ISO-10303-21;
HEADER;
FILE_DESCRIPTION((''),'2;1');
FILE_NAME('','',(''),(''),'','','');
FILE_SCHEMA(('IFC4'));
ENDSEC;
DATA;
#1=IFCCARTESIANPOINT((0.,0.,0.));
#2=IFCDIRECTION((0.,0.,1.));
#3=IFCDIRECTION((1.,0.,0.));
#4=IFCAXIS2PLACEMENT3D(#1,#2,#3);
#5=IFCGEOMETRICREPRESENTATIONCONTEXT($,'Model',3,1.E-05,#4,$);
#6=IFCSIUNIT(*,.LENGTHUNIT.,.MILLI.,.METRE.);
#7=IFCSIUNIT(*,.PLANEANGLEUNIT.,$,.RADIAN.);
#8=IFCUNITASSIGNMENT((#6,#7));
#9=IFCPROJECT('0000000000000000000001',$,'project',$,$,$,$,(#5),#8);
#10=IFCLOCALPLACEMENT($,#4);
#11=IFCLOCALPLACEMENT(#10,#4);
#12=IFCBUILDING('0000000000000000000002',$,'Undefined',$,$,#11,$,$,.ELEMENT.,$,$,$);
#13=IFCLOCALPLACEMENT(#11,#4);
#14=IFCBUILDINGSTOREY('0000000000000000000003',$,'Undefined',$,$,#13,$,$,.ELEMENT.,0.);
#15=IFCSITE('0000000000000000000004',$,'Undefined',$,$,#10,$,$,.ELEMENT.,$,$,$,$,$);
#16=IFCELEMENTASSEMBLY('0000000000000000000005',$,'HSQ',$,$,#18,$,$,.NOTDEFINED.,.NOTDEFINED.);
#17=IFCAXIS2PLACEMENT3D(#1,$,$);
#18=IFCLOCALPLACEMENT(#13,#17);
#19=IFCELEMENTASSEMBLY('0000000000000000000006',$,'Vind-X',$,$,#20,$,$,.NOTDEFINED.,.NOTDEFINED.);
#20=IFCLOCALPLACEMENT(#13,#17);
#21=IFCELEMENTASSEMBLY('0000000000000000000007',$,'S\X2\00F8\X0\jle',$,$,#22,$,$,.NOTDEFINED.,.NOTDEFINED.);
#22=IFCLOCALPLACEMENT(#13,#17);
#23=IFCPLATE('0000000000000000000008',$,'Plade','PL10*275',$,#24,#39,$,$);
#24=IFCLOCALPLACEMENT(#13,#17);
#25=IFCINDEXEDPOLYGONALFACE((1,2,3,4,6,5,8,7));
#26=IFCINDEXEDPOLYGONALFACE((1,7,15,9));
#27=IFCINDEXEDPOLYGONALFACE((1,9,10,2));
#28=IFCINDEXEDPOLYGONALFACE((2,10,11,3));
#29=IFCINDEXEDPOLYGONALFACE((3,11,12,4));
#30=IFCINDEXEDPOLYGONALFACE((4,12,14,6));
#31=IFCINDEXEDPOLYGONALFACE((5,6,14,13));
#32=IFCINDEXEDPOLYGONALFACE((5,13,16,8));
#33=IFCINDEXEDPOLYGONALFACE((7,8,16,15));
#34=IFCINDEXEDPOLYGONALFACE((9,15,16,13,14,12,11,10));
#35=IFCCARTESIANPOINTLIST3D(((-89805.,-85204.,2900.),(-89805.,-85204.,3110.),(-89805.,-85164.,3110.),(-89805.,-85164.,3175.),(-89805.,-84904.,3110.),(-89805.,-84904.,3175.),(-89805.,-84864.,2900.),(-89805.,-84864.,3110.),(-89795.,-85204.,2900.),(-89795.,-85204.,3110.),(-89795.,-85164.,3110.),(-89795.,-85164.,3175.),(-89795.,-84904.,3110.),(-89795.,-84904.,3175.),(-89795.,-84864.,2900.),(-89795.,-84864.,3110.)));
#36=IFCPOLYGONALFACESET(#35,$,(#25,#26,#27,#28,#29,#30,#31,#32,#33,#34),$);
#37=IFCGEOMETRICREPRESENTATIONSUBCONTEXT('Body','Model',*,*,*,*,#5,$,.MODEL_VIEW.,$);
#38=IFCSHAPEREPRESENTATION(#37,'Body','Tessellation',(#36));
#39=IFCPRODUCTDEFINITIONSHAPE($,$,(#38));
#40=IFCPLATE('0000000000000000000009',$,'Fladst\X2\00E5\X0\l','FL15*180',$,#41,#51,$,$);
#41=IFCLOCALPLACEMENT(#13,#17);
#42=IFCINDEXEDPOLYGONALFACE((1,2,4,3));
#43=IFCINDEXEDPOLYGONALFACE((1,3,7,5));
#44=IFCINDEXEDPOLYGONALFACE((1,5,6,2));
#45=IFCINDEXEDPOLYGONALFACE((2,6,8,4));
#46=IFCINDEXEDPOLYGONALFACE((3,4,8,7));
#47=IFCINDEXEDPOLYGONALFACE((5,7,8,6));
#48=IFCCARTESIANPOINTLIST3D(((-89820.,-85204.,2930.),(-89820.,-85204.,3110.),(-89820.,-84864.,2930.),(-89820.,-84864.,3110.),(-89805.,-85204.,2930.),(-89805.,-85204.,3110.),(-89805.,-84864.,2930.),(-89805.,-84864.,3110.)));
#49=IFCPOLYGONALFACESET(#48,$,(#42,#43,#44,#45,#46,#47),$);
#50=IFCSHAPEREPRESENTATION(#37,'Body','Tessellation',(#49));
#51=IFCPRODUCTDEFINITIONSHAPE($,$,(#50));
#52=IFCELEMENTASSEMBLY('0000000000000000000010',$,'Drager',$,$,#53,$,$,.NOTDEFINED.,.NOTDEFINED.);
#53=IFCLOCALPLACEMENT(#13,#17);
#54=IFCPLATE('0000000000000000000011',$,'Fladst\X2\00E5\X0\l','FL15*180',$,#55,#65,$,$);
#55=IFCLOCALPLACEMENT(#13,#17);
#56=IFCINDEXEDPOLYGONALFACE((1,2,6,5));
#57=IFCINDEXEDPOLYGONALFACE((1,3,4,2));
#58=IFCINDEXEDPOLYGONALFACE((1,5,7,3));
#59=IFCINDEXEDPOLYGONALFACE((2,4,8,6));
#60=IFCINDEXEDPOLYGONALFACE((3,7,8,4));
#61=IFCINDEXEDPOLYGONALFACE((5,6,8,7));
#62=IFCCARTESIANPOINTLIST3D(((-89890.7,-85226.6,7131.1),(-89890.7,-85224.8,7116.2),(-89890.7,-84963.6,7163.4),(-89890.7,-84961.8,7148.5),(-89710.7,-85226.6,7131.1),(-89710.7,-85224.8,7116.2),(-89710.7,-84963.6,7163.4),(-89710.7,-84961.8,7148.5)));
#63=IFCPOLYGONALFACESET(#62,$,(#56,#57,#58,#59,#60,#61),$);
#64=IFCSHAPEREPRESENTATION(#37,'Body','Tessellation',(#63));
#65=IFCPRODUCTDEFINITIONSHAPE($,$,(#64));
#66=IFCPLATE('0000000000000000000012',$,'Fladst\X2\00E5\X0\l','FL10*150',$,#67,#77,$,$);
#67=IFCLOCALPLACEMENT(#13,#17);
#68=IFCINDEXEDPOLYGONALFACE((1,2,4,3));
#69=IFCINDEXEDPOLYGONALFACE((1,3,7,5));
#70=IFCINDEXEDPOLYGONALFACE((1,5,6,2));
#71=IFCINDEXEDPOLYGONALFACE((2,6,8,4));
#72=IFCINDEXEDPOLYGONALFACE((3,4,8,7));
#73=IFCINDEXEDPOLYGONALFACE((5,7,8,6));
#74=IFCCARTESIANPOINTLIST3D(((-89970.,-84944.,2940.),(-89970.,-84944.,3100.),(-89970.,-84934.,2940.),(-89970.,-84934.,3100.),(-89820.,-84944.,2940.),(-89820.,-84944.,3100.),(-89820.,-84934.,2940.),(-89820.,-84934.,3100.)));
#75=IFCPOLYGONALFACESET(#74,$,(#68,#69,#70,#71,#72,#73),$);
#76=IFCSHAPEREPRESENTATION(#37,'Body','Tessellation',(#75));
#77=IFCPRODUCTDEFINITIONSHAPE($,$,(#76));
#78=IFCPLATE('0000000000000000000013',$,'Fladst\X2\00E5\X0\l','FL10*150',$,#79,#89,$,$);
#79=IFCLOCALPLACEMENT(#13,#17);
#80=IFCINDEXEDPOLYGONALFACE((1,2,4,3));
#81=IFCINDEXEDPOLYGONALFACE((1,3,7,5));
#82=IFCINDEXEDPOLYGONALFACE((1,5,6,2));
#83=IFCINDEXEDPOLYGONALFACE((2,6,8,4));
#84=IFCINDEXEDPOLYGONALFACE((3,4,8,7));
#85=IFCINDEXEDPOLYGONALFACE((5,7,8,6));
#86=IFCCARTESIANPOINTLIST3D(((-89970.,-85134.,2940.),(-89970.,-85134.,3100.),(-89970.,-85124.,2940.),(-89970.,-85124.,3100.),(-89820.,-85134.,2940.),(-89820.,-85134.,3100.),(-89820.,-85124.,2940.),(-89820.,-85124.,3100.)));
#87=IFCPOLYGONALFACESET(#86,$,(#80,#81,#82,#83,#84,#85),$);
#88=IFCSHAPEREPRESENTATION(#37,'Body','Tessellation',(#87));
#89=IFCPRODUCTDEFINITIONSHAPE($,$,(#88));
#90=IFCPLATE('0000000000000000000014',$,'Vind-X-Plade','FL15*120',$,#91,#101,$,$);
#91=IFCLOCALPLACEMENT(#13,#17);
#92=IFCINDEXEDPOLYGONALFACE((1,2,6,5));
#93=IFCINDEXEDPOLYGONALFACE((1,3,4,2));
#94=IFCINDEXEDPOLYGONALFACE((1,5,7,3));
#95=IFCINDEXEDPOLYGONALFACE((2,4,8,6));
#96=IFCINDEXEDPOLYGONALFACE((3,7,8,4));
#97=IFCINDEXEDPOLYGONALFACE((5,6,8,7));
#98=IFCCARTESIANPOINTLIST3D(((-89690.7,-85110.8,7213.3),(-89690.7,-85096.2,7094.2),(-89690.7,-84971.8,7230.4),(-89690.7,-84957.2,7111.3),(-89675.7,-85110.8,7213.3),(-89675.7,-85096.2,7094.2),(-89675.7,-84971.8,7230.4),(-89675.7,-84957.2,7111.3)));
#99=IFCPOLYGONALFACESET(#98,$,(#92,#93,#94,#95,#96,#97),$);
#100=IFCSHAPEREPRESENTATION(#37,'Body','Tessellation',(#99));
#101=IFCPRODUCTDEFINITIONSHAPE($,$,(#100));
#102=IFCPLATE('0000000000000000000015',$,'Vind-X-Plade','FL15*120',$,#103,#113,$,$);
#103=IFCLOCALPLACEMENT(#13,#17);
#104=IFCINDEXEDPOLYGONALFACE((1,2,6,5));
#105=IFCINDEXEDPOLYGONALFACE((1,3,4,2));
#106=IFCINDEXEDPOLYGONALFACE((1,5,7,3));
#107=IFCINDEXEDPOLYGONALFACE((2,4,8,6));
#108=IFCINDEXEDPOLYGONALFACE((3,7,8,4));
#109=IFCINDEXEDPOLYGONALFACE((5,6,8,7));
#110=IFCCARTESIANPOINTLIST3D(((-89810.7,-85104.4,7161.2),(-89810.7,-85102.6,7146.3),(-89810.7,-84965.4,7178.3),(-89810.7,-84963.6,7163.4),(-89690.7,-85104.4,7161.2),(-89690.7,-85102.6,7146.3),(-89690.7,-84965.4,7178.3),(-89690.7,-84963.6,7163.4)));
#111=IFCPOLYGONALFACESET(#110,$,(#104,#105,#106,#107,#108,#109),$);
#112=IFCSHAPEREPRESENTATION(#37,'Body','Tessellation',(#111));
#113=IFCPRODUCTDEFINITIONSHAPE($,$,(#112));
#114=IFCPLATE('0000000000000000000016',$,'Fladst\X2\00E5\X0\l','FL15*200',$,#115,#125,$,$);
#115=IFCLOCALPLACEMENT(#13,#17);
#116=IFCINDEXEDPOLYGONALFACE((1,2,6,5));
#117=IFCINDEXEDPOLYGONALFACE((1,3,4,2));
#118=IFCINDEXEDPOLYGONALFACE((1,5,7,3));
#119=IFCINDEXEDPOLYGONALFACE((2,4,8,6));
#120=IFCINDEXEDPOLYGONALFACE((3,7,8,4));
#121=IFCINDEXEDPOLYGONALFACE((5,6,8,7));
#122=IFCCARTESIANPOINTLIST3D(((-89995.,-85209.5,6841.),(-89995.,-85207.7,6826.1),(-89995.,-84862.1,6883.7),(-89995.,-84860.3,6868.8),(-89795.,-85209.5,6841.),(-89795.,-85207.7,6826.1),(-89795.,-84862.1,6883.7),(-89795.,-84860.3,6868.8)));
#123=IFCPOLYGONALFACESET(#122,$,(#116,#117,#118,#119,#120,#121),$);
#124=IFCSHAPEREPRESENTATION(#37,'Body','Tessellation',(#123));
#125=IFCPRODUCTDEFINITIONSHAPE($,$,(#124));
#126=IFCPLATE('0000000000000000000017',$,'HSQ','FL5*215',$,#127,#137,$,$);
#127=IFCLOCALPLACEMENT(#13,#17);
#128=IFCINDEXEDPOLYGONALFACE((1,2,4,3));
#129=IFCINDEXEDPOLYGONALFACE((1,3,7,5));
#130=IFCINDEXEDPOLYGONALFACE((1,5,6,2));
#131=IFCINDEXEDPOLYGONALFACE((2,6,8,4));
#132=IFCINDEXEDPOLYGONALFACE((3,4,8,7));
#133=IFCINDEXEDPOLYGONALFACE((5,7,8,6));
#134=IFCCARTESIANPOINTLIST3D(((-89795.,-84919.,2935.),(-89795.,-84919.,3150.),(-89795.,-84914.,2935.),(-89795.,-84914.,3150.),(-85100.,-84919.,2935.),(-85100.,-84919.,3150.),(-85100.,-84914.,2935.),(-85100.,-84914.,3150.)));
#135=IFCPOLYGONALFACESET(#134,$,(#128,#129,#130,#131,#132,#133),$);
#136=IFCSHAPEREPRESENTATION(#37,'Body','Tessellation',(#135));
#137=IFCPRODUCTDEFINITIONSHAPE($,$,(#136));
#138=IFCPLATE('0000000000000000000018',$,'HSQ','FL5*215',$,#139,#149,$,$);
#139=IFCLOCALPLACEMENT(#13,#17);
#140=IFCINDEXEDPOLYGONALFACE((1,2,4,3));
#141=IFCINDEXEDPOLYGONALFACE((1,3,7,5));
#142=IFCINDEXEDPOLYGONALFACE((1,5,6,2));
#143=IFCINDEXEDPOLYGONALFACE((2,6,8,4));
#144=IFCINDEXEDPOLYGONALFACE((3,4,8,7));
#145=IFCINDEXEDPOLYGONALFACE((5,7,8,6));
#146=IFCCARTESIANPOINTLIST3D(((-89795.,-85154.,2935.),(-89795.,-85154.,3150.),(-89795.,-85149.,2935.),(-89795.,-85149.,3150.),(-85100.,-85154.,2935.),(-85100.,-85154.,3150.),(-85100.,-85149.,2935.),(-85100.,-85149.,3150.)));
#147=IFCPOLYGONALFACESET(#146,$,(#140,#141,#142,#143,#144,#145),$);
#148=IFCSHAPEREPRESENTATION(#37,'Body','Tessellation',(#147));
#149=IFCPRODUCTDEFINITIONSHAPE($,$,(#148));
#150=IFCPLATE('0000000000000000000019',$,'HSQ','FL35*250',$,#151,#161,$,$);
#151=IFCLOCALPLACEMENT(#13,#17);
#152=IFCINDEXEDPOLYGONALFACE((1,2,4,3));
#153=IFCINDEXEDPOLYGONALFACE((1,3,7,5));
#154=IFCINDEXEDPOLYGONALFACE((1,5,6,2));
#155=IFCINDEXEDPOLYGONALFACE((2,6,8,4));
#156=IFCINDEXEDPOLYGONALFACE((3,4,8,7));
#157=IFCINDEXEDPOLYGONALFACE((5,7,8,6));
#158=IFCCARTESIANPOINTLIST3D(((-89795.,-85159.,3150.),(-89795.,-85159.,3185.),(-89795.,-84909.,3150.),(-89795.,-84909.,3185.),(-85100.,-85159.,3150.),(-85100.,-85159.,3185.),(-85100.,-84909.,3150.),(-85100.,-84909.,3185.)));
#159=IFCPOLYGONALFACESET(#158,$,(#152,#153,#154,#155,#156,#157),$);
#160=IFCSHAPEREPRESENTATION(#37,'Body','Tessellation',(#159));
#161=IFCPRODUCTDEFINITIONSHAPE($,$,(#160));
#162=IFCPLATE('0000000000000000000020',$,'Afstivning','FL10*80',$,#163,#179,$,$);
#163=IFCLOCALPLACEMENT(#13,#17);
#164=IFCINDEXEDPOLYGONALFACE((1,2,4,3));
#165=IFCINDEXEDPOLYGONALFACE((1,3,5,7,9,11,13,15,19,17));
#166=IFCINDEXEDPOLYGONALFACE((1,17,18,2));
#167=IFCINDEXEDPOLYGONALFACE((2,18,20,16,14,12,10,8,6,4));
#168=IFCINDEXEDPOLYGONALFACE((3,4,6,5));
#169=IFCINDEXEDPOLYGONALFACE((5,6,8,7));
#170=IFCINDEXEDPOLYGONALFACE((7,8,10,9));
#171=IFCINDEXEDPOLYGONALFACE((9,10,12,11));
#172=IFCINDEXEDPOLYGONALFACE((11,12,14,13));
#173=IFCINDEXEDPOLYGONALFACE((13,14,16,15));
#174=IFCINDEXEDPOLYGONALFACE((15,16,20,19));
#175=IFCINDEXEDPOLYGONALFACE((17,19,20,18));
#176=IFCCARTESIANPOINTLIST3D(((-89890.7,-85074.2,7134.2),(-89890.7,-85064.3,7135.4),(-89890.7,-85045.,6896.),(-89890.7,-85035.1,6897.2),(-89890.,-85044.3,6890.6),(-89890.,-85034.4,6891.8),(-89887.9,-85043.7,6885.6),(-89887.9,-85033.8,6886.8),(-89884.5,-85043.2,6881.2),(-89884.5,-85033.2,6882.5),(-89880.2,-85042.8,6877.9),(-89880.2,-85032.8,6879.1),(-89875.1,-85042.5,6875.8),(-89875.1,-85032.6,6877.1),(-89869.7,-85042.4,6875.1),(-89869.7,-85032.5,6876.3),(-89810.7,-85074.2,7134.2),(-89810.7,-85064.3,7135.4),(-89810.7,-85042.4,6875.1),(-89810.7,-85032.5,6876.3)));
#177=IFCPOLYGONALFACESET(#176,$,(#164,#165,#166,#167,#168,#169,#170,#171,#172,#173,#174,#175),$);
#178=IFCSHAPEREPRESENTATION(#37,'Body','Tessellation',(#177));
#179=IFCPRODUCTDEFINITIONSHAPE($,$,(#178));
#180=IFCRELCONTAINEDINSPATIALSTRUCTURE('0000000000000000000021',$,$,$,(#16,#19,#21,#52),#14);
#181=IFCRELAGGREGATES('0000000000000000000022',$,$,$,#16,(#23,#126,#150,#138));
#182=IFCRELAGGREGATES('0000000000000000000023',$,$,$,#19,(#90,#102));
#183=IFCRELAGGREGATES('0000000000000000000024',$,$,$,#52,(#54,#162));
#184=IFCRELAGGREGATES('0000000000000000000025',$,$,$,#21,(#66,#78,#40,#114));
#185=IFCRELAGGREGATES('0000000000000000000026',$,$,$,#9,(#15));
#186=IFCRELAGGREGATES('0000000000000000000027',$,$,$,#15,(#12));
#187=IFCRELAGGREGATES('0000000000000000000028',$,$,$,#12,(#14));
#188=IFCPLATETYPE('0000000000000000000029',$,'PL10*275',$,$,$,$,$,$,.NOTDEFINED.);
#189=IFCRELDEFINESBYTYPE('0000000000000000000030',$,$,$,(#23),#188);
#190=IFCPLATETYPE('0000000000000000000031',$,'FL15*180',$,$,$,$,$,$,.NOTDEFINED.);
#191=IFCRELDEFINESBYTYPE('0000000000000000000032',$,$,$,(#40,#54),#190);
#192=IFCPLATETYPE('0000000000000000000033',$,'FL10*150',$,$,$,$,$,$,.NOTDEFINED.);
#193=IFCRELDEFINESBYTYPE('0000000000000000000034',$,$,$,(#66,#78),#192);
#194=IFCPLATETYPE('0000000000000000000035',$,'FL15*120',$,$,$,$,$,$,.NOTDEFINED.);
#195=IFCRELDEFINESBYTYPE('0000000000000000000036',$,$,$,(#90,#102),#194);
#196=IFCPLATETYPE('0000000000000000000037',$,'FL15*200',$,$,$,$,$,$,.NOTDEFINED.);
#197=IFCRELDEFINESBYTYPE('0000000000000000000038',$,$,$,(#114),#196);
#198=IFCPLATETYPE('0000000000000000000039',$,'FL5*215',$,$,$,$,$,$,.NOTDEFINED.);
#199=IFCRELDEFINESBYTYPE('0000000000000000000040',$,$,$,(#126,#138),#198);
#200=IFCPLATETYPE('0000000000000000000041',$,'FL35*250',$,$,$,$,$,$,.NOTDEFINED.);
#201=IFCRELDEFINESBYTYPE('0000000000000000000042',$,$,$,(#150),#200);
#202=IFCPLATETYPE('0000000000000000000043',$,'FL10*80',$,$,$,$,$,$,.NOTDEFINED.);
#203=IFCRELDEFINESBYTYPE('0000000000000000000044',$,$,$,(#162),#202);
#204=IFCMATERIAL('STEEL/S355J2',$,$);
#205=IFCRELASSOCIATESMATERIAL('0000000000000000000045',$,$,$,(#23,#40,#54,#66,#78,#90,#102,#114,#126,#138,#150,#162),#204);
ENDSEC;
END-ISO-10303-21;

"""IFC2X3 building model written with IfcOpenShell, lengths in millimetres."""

from ifc_helpers import new_model, si_unit, frame, frame_2d, origin_with_axes, place, context, subcontext, project, spatial, polyline, circle_curve, parameter, trimmed, segment, composite_curve, outline, extrude, material, type_object, element, aggregate, save


model = new_model("IFC2X3")

# Units and contexts
model_context = context("Model", 3, precision=1e-05, world=origin_with_axes())
body_context = subcontext(model_context, "Body", "Model", "MODEL_VIEW")
ifc_project = project(units=[si_unit("LENGTHUNIT", "METRE", prefix="MILLI"), si_unit("PLANEANGLEUNIT", "RADIAN")], contexts=[model_context])

# Site, building, storey
site_placement = place(None, origin_with_axes())
site = spatial("IfcSite", under=ifc_project, at=site_placement, Name="Undefined", CompositionType="ELEMENT")
building_placement = place(site_placement, origin_with_axes())
building = spatial("IfcBuilding", under=site, at=building_placement, Name="Undefined", CompositionType="ELEMENT")
storey_placement = place(building_placement, origin_with_axes())
storey = spatial("IfcBuildingStorey", under=building, at=storey_placement, Name="Undefined", CompositionType="ELEMENT", Elevation=0.0)

# Shared definitions
ifc_material_1 = material(Name="STEEL/S355J2")

# Element assembly
assembly_1_placement = place(storey_placement, origin_with_axes())
assembly_1 = element("IfcElementAssembly", 1, at=assembly_1_placement, inside=storey, Name="HSQ", AssemblyPlace="NOTDEFINED", PredefinedType="NOTDEFINED")

# Element assembly
assembly_2_placement = place(storey_placement, origin_with_axes())
assembly_2 = element("IfcElementAssembly", 2, at=assembly_2_placement, inside=storey, Name="Vind-X", AssemblyPlace="NOTDEFINED", PredefinedType="NOTDEFINED")

# Element assembly
assembly_3_placement = place(storey_placement, origin_with_axes())
assembly_3 = element("IfcElementAssembly", 3, at=assembly_3_placement, inside=storey, Name="Søjle", AssemblyPlace="NOTDEFINED", PredefinedType="NOTDEFINED")

# Plates
plate_type_1 = type_object("IfcPlateType", Name="PL10*275", PredefinedType="NOTDEFINED")
plate_1_placement = place(assembly_1_placement, frame((-89800.0, -84864.0, 3175.0), z_axis=(1.0, 0.0, 0.0), x_axis=(0.0, -1.0, 0.0)))
plate_1 = element("IfcPlate", 4, at=plate_1_placement, type_object=plate_type_1, material=ifc_material_1, Name="Plade", Description="PL10*275", context=body_context, shape_type="SweptSolid", body=[
    extrude(outline(polyline([(0.0, 65.0), (40.0, 65.0), (40.0, 0.0), (300.0, 0.0), (300.0, 65.0), (340.0, 65.0), (340.0, 275.0), (0.0, 275.0), (0.0, 65.0)])), frame((0.0, 0.0, -5.0), z_axis=(0.0, 0.0, 1.0), x_axis=(1.0, 0.0, 0.0)), (0.0, 0.0, 1.0), 10.0),
])
plate_type_2 = type_object("IfcPlateType", Name="FL15*180", PredefinedType="NOTDEFINED")
plate_2_placement = place(assembly_3_placement, frame((-89812.5, -84864.0, 3110.0), z_axis=(1.0, 0.0, 0.0), x_axis=(0.0, -1.0, 0.0)))
plate_2 = element("IfcPlate", 5, at=plate_2_placement, type_object=plate_type_2, material=ifc_material_1, Name="Fladstål", Description="FL15*180", context=body_context, shape_type="SweptSolid", body=[
    extrude(outline(polyline([(0.0, 0.0), (340.0, 0.0), (340.0, 180.0), (0.0, 180.0), (0.0, 0.0)])), frame((0.0, 0.0, -7.5), z_axis=(0.0, 0.0, 1.0), x_axis=(1.0, 0.0, 0.0)), (0.0, 0.0, 1.0), 15.0),
])

# Element assembly, plate
assembly_4_placement = place(storey_placement, origin_with_axes())
assembly_4 = element("IfcElementAssembly", 6, at=assembly_4_placement, inside=storey, Name="Drager", AssemblyPlace="NOTDEFINED", PredefinedType="NOTDEFINED")
plate_3_placement = place(assembly_4_placement, frame((-89890.7, -84962.7, 7155.9), z_axis=(0.0, -0.121869, 0.992546), x_axis=(0.0, -0.992546, -0.121869)))
plate_3 = element("IfcPlate", 7, at=plate_3_placement, type_object=plate_type_2, material=ifc_material_1, Name="Fladstål", Description="FL15*180", context=body_context, shape_type="SweptSolid", body=[
    extrude(outline(polyline([(0.0, 0.0), (265.0, 0.0), (265.0, 180.0), (0.0, 180.0), (0.0, 0.0)])), frame((0.0, 0.0, -7.5), z_axis=(0.0, 0.0, 1.0), x_axis=(1.0, 0.0, 0.0)), (0.0, 0.0, 1.0), 15.0),
])

# Plates
plate_type_3 = type_object("IfcPlateType", Name="FL10*150", PredefinedType="NOTDEFINED")
plate_4_placement = place(assembly_3_placement, frame((-89820.0, -84939.0, 3100.0), z_axis=(0.0, -1.0, 0.0), x_axis=(-1.0, 0.0, 0.0)))
plate_4 = element("IfcPlate", 8, at=plate_4_placement, type_object=plate_type_3, material=ifc_material_1, Name="Fladstål", Description="FL10*150", context=body_context, shape_type="SweptSolid", body=[
    extrude(outline(polyline([(0.0, 0.0), (150.0, 0.0), (150.0, 160.0), (0.0, 160.0), (0.0, 0.0)])), frame((0.0, 0.0, -5.0), z_axis=(0.0, 0.0, 1.0), x_axis=(1.0, 0.0, 0.0)), (0.0, 0.0, 1.0), 10.0),
])
plate_5_placement = place(assembly_3_placement, frame((-89820.0, -85129.0, 3100.0), z_axis=(0.0, -1.0, 0.0), x_axis=(-1.0, 0.0, 0.0)))
plate_5 = element("IfcPlate", 9, at=plate_5_placement, type_object=plate_type_3, material=ifc_material_1, Name="Fladstål", Description="FL10*150", context=body_context, shape_type="SweptSolid", body=[
    extrude(outline(polyline([(0.0, 0.0), (150.0, 0.0), (150.0, 160.0), (0.0, 160.0), (0.0, 0.0)])), frame((0.0, 0.0, -5.0), z_axis=(0.0, 0.0, 1.0), x_axis=(1.0, 0.0, 0.0)), (0.0, 0.0, 1.0), 10.0),
])
plate_type_4 = type_object("IfcPlateType", Name="FL15*120", PredefinedType="NOTDEFINED")
plate_6_placement = place(assembly_2_placement, frame((-89683.2, -84957.2, 7111.3), z_axis=(-1.0, 0.0, 0.0), x_axis=(0.0, -0.992546, -0.121869)))
plate_6 = element("IfcPlate", 10, at=plate_6_placement, type_object=plate_type_4, material=ifc_material_1, Name="Vind-X-Plade", Description="FL15*120", context=body_context, shape_type="SweptSolid", body=[
    extrude(outline(polyline([(0.0, 0.0), (140.0, 0.0), (140.0, 120.0), (0.0, 120.0), (0.0, 0.0)])), frame((0.0, 0.0, -7.5), z_axis=(0.0, 0.0, 1.0), x_axis=(1.0, 0.0, 0.0)), (0.0, 0.0, 1.0), 15.0),
])
plate_7_placement = place(assembly_2_placement, frame((-89810.7, -85034.0, 7162.3), z_axis=(0.0, 0.121869, -0.992546), x_axis=(1.0, 0.0, 0.0)))
plate_7 = element("IfcPlate", 11, at=plate_7_placement, type_object=plate_type_4, material=ifc_material_1, Name="Vind-X-Plade", Description="FL15*120", context=body_context, shape_type="SweptSolid", body=[
    extrude(outline(polyline([(0.0, -70.0), (0.0, 70.0), (120.0, 70.0), (120.0, -70.0), (0.0, -70.0)])), frame((0.0, 0.0, -7.5), z_axis=(0.0, 0.0, 1.0), x_axis=(1.0, 0.0, 0.0)), (0.0, 0.0, 1.0), 15.0),
])
plate_type_5 = type_object("IfcPlateType", Name="FL15*200", PredefinedType="NOTDEFINED")
plate_8_placement = place(assembly_3_placement, frame((-89895.0, -85208.6, 6833.6), z_axis=(0.0, 0.121869, -0.992546), x_axis=(0.0, 0.992546, 0.121869)))
plate_8 = element("IfcPlate", 12, at=plate_8_placement, type_object=plate_type_5, material=ifc_material_1, Name="Fladstål", Description="FL15*200", context=body_context, shape_type="SweptSolid", body=[
    extrude(outline(polyline([(0.0, -100.0), (0.0, 100.0), (350.0, 100.0), (350.0, -100.0), (0.0, -100.0)])), frame((0.0, 0.0, -7.5), z_axis=(0.0, 0.0, 1.0), x_axis=(1.0, 0.0, 0.0)), (0.0, 0.0, 1.0), 15.0),
])
plate_type_6 = type_object("IfcPlateType", Name="FL5*215", PredefinedType="NOTDEFINED")
plate_9_placement = place(assembly_1_placement, frame((-89795.0, -84916.5, 3042.5), z_axis=(0.0, -1.0, 0.0), x_axis=(1.0, 0.0, 0.0)))
plate_9 = element("IfcPlate", 13, at=plate_9_placement, type_object=plate_type_6, material=ifc_material_1, Name="HSQ", Description="FL5*215", context=body_context, shape_type="SweptSolid", body=[
    extrude(outline(polyline([(0.0, -107.5), (0.0, 107.5), (4695.0, 107.5), (4695.0, -107.5), (0.0, -107.5)])), frame((0.0, 0.0, -2.5), z_axis=(0.0, 0.0, 1.0), x_axis=(1.0, 0.0, 0.0)), (0.0, 0.0, 1.0), 5.0),
])
plate_10_placement = place(assembly_1_placement, frame((-89795.0, -85151.5, 3042.5), z_axis=(0.0, -1.0, 0.0), x_axis=(1.0, 0.0, 0.0)))
plate_10 = element("IfcPlate", 14, at=plate_10_placement, type_object=plate_type_6, material=ifc_material_1, Name="HSQ", Description="FL5*215", context=body_context, shape_type="SweptSolid", body=[
    extrude(outline(polyline([(0.0, -107.5), (0.0, 107.5), (4695.0, 107.5), (4695.0, -107.5), (0.0, -107.5)])), frame((0.0, 0.0, -2.5), z_axis=(0.0, 0.0, 1.0), x_axis=(1.0, 0.0, 0.0)), (0.0, 0.0, 1.0), 5.0),
])
plate_type_7 = type_object("IfcPlateType", Name="FL35*250", PredefinedType="NOTDEFINED")
plate_11_placement = place(assembly_1_placement, frame((-89795.0, -85034.0, 3167.5), z_axis=(0.0, 0.0, 1.0), x_axis=(1.0, 0.0, 0.0)))
plate_11 = element("IfcPlate", 15, at=plate_11_placement, type_object=plate_type_7, material=ifc_material_1, Name="HSQ", Description="FL35*250", context=body_context, shape_type="SweptSolid", body=[
    extrude(outline(polyline([(0.0, -125.0), (0.0, 125.0), (4695.0, 125.0), (4695.0, -125.0), (0.0, -125.0)])), frame((0.0, 0.0, -17.5), z_axis=(0.0, 0.0, 1.0), x_axis=(1.0, 0.0, 0.0)), (0.0, 0.0, 1.0), 35.0),
])
aggregate(assembly_1, [plate_1, plate_9, plate_11, plate_10])
plate_type_8 = type_object("IfcPlateType", Name="FL10*80", PredefinedType="NOTDEFINED")
plate_12_placement = place(assembly_4_placement, frame((-89890.7, -85037.5, 6875.7), z_axis=(0.0, -0.992546, -0.121869), x_axis=(1.0, 0.0, 0.0)))
plate_12 = element("IfcPlate", 16, at=plate_12_placement, type_object=plate_type_8, material=ifc_material_1, Name="Afstivning", Description="FL10*80", context=body_context, shape_type="SweptSolid", body=[
    extrude(outline(composite_curve([segment(trimmed(circle_curve(frame_2d((21.0, 21.0), x_axis=(-1.0, 0.0)), 21.0), [parameter(0.0)], [parameter(1.570796)], True, "PARAMETER"), True, "CONTINUOUS"), segment(polyline([(21.0, 0.0), (80.0, 0.0), (80.0, 261.0), (0.0, 261.0), (0.0, 21.0)]), True, "CONTINUOUS")], self_intersect=True)), frame((0.0, 0.0, -5.0), z_axis=(0.0, 0.0, 1.0), x_axis=(1.0, 0.0, 0.0)), (0.0, 0.0, 1.0), 10.0),
])

aggregate(assembly_2, [plate_6, plate_7])
aggregate(assembly_4, [plate_3, plate_12])
aggregate(assembly_3, [plate_4, plate_5, plate_2, plate_8])

save(model, "model.ifc")
